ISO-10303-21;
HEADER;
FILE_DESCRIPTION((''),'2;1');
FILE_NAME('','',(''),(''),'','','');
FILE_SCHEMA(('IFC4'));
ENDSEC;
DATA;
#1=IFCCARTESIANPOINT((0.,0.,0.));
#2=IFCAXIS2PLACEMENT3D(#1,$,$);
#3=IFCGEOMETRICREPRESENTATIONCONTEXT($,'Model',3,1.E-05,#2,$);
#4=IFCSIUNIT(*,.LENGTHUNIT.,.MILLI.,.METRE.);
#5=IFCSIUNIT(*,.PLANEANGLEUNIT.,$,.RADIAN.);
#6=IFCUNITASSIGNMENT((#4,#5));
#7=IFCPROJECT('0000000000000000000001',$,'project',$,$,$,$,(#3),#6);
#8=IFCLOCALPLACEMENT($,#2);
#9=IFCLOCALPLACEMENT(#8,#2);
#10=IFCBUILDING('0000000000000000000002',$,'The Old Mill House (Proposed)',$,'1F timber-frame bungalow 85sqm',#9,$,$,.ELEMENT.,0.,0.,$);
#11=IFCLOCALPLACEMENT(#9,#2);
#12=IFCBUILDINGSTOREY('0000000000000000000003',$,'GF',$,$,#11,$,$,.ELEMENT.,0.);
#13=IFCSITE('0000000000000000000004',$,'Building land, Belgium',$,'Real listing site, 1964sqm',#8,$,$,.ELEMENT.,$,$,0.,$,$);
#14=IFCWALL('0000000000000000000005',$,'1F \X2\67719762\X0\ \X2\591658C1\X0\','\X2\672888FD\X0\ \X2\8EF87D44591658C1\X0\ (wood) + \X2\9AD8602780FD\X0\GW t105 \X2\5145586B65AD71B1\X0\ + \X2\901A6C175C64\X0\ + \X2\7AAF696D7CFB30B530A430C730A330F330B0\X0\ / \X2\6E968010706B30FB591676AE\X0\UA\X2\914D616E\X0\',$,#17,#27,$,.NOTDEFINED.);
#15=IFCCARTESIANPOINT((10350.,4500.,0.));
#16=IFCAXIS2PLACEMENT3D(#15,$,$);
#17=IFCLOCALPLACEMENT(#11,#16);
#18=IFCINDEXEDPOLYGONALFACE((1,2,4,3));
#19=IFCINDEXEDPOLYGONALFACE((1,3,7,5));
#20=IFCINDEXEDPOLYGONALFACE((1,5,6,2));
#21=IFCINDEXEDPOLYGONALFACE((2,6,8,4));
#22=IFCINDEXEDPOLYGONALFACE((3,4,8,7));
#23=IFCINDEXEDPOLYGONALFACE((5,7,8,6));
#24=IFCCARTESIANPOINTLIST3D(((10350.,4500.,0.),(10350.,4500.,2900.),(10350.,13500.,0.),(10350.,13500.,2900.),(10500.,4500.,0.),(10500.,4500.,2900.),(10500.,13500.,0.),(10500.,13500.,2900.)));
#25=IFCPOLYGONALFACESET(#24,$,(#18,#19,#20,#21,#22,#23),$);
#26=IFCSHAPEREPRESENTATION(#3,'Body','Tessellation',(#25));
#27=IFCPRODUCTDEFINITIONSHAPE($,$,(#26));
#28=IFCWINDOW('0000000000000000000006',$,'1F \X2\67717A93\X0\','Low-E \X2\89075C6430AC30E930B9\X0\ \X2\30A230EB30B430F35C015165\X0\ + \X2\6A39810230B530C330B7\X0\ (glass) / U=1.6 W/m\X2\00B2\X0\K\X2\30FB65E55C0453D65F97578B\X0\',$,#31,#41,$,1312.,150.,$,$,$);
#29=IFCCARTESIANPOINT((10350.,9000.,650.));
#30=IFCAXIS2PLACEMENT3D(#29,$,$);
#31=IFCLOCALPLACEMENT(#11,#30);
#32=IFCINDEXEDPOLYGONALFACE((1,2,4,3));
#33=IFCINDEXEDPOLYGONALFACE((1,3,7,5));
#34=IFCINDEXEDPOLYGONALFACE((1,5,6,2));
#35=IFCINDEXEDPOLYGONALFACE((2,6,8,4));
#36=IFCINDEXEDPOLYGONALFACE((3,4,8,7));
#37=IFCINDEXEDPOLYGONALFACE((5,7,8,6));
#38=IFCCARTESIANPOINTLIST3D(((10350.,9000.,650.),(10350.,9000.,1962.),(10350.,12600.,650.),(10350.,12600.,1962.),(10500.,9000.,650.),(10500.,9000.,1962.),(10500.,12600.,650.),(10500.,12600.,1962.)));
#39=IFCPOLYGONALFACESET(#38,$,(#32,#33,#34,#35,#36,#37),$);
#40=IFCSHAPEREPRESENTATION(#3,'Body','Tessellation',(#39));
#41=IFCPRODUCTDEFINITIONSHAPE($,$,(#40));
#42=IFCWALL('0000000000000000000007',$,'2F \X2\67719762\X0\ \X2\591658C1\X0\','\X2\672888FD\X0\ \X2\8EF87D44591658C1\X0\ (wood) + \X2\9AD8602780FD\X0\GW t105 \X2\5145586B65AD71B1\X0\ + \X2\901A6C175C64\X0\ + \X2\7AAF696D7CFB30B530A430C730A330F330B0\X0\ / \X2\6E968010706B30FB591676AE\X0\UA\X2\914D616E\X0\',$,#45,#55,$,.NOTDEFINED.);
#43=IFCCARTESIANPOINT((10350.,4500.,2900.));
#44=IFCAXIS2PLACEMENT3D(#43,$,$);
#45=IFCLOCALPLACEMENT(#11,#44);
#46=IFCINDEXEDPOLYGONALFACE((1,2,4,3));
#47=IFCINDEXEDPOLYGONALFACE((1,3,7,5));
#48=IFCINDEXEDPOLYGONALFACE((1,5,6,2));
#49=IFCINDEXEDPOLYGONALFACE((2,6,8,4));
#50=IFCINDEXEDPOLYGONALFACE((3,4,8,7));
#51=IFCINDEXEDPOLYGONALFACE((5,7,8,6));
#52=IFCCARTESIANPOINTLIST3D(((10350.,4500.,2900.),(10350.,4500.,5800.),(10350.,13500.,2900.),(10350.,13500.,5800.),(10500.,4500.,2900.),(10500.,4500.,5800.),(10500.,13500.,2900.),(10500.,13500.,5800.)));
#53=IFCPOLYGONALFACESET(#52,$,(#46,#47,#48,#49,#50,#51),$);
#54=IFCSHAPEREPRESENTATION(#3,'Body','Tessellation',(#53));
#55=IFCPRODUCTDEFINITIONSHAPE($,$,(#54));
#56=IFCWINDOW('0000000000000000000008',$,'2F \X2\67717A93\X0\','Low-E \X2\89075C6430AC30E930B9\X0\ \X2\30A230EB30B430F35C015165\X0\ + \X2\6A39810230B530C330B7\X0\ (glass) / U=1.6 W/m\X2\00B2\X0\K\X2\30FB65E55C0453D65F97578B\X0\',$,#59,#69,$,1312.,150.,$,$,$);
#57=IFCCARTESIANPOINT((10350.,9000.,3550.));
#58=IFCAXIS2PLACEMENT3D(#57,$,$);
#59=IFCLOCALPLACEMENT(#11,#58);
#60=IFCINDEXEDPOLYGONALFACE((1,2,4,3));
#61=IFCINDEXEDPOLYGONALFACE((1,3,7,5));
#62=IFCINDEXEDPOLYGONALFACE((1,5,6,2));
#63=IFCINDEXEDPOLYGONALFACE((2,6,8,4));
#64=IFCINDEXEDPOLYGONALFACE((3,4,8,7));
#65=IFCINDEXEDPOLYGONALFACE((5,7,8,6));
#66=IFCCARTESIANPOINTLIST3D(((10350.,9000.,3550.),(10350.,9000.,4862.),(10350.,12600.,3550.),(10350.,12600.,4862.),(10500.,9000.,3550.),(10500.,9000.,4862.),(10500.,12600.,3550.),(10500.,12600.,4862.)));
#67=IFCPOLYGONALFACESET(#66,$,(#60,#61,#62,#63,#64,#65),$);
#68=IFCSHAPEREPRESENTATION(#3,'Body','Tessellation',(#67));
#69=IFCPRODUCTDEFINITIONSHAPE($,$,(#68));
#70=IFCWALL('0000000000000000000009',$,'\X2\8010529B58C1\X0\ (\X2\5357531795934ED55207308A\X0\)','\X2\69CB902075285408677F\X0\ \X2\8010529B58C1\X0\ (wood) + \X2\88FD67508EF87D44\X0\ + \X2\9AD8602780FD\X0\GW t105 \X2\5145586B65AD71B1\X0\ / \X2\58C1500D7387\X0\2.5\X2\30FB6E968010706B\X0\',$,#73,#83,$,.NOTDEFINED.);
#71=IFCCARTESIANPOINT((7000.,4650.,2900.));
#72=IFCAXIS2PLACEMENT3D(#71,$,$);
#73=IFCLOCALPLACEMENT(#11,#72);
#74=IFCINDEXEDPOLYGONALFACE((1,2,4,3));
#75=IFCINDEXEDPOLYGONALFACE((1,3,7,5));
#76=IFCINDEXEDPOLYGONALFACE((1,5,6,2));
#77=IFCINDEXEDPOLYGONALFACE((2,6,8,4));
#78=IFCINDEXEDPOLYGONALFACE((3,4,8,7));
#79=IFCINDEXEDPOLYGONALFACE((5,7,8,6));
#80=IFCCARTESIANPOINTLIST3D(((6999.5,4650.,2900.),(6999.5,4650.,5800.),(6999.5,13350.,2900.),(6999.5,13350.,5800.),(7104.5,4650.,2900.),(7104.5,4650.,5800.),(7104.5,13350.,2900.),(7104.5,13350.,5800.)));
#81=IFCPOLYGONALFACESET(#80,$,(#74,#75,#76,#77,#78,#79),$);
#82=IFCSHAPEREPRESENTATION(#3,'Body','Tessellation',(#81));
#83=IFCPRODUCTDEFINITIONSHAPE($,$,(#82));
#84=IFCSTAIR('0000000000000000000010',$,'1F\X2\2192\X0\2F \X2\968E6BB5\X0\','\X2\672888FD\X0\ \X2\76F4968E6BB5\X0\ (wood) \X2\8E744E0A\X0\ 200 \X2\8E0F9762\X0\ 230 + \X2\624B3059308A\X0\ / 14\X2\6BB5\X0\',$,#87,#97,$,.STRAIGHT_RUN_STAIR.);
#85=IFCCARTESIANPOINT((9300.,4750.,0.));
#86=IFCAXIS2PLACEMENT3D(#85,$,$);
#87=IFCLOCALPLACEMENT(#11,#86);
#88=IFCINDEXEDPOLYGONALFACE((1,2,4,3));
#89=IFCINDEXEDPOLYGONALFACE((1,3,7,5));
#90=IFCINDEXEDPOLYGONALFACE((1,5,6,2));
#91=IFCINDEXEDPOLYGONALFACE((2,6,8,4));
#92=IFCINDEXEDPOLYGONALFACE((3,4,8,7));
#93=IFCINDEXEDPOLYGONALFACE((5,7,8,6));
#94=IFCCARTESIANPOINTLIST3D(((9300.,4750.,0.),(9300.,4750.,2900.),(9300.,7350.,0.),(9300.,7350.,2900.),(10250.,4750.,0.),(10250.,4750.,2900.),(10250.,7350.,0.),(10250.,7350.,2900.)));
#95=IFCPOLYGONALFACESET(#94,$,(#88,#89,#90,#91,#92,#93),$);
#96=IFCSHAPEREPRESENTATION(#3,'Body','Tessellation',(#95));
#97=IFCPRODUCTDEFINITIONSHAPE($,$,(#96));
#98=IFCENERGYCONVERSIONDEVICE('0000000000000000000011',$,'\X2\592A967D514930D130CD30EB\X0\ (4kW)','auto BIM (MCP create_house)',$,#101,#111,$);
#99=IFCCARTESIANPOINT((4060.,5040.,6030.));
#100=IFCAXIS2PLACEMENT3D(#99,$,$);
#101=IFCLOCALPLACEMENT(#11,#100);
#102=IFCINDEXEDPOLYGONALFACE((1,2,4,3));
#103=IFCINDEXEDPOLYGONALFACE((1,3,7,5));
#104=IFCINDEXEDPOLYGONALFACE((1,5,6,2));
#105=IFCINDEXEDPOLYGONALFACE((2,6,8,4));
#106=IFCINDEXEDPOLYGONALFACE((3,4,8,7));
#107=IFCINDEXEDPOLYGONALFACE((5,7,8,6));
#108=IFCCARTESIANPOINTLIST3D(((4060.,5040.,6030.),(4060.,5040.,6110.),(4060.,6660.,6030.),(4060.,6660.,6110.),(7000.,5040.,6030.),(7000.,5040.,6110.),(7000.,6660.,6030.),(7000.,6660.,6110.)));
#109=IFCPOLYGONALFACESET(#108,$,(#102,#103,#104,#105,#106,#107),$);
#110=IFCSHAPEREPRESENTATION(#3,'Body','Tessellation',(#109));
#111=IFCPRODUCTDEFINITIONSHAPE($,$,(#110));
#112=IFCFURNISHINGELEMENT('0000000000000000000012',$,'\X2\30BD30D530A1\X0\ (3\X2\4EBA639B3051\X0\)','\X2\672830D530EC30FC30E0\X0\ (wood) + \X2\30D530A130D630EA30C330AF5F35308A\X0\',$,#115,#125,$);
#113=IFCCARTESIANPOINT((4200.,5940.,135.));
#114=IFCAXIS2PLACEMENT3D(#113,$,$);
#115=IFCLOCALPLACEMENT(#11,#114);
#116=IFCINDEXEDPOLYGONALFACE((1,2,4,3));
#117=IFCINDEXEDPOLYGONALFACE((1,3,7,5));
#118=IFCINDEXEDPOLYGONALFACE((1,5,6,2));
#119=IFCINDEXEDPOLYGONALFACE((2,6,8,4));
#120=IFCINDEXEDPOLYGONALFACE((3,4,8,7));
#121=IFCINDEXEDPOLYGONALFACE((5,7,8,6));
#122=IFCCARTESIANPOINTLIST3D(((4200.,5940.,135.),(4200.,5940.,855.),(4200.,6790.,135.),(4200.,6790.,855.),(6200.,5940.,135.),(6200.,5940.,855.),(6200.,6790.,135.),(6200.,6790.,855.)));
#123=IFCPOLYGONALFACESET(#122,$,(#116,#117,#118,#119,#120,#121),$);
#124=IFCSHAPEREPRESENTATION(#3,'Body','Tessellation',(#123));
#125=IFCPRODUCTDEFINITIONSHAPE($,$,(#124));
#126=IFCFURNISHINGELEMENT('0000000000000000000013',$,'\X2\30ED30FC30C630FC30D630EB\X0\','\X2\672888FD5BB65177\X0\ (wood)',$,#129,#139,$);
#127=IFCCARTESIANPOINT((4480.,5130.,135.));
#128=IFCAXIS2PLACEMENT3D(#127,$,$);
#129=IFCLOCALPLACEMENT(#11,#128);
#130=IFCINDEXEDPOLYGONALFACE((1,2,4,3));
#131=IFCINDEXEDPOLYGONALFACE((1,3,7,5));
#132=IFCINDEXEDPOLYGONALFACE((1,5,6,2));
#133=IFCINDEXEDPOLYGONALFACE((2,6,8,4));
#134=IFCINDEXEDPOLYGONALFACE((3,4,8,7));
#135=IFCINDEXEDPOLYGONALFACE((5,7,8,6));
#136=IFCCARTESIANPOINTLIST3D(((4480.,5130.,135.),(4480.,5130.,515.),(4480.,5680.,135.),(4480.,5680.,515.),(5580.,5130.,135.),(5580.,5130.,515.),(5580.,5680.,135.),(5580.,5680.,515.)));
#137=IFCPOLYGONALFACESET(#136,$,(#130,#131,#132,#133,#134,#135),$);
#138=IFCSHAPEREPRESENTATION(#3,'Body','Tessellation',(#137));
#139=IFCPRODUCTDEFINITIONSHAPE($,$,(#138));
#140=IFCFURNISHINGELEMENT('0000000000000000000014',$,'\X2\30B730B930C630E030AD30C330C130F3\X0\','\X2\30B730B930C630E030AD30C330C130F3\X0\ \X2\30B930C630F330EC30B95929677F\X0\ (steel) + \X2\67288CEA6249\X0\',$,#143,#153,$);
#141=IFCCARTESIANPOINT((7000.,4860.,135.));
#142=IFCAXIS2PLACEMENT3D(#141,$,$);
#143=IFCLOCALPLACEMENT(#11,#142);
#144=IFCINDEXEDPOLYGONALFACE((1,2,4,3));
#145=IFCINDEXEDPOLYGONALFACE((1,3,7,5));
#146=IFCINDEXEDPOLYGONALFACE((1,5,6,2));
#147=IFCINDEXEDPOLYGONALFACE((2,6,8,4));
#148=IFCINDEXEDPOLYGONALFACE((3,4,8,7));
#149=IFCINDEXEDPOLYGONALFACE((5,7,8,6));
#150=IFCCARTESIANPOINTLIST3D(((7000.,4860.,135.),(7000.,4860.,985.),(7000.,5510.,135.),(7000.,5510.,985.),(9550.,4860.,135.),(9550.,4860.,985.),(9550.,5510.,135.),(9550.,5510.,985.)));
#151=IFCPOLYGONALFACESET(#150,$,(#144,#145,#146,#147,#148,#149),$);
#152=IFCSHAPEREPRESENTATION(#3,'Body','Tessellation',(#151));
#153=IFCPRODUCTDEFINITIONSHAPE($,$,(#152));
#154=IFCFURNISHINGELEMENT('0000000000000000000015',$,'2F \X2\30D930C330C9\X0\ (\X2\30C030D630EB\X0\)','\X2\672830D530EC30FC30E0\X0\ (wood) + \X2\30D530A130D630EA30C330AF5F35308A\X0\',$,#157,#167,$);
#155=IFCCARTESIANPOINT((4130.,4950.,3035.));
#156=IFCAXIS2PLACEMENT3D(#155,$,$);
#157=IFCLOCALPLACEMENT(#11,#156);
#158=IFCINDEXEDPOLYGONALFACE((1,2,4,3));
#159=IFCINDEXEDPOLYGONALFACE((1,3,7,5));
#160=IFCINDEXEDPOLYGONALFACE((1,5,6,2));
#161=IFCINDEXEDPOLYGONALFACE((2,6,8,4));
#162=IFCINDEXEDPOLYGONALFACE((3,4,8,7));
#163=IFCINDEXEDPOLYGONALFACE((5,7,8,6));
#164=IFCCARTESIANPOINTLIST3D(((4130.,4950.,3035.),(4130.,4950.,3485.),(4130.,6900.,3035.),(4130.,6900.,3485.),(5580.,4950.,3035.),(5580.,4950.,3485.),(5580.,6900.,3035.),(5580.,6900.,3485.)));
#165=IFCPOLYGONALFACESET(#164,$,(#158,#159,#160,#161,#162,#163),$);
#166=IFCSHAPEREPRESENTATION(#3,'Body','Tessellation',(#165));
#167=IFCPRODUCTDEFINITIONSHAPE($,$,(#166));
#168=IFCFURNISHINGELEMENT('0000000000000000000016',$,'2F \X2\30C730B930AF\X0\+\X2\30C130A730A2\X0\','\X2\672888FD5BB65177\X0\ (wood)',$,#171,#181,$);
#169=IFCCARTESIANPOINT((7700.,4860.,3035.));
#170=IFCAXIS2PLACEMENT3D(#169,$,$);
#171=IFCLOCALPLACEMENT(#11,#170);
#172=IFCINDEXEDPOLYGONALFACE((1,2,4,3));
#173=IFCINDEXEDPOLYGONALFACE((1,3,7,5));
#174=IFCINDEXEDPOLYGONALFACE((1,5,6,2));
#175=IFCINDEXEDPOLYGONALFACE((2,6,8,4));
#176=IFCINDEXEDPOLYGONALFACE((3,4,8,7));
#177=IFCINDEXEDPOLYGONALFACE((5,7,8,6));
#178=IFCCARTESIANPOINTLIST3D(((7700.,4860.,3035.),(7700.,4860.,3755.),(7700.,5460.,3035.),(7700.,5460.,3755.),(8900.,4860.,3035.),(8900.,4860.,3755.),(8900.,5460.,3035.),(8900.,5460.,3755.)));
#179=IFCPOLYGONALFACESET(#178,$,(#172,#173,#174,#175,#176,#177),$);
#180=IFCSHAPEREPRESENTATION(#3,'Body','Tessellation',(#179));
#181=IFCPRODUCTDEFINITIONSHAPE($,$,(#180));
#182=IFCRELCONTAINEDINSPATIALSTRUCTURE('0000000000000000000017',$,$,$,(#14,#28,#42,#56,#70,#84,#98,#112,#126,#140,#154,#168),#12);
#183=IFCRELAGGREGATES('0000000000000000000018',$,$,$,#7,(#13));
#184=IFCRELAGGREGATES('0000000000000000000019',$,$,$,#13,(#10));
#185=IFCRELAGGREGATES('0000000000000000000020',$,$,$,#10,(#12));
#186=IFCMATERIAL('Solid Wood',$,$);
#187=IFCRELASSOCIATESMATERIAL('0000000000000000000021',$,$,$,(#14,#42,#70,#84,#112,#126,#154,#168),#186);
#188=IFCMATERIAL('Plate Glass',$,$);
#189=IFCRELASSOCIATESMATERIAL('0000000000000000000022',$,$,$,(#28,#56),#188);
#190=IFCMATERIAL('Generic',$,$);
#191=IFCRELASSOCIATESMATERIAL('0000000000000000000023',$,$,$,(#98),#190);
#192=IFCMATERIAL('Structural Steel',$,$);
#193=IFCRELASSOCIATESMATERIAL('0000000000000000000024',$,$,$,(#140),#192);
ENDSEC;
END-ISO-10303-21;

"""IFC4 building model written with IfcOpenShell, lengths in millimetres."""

from ifc_helpers import new_model, si_unit, frame, frame_2d, origin, place, context, project, spatial, rectangle, extrude, material, element, fill, save


model = new_model("IFC4")

# Units and contexts
model_context = context("Model", 3, precision=1e-05, world=origin())
ifc_project = project(units=[si_unit("LENGTHUNIT", "METRE", prefix="MILLI"), si_unit("PLANEANGLEUNIT", "RADIAN")], contexts=[model_context])

# Site, building, storey
site_placement = place(None, origin())
site = spatial("IfcSite", under=ifc_project, at=site_placement, Name="Building land, Belgium", ObjectType="Real listing site, 1964sqm", CompositionType="ELEMENT", RefElevation=0.0)
building_placement = place(site_placement, origin())
building = spatial("IfcBuilding", under=site, at=building_placement, Name="The Old Mill House (Proposed)", ObjectType="1F timber-frame bungalow 85sqm", CompositionType="ELEMENT", ElevationOfRefHeight=0.0, ElevationOfTerrain=0.0)
storey_placement = place(building_placement, origin())
storey = spatial("IfcBuildingStorey", under=building, at=storey_placement, Name="GF", CompositionType="ELEMENT", Elevation=0.0)

# Wall, opening, window
ifc_material_1 = material(Name="Solid Wood")
wall_1_placement = place(storey_placement, frame((10350.0, 4500.0, 0.0)))
wall_1 = element("IfcWall", 1, at=wall_1_placement, inside=storey, material=ifc_material_1, Name="1F 東面 外壁", Description="木製 軸組外壁 (wood) + 高性能GW t105 充填断熱 + 通気層 + 窯業系サイディング / 準耐火・外皮UA配慮", PredefinedType="NOTDEFINED", context=model_context, shape_type="SweptSolid", body=[
    extrude(rectangle(XDim=150.0, YDim=9000.0, at=frame_2d((75.0, 4500.0))), frame((10350.0, 4500.0, 0.0)), (0.0, 0.0, 1.0), 2900.0),
])
opening_1_placement = place(storey_placement, frame((10350.0, 9000.0, 650.0)))
opening_1 = element("IfcOpeningElement", 2, at=opening_1_placement, cuts=wall_1, PredefinedType="NOTDEFINED", context=model_context, shape_type="SweptSolid", body=[
    extrude(rectangle(XDim=150.0, YDim=3600.0, at=frame_2d((75.0, 1800.0))), frame((10350.0, 9000.0, 650.0)), (0.0, 0.0, 1.0), 1312.0),
])
ifc_material_2 = material(Name="Plate Glass")
window_1_placement = place(storey_placement, frame((10350.0, 9000.0, 650.0)))
window_1 = element("IfcWindow", 3, at=window_1_placement, inside=storey, material=ifc_material_2, Name="1F 東窓", Description="Low-E 複層ガラス アルゴン封入 + 樹脂サッシ (glass) / U=1.6 W/m²K・日射取得型", OverallHeight=1312.0, OverallWidth=150.0, context=model_context, shape_type="SweptSolid", body=[
    extrude(rectangle(XDim=150.0, YDim=3600.0, at=frame_2d((75.0, 1800.0))), frame((10350.0, 9000.0, 650.0)), (0.0, 0.0, 1.0), 1312.0),
])
fill(opening_1, window_1)

# Wall, opening, window
wall_2_placement = place(storey_placement, frame((10350.0, 4500.0, 2900.0)))
wall_2 = element("IfcWall", 4, at=wall_2_placement, inside=storey, material=ifc_material_1, Name="2F 東面 外壁", Description="木製 軸組外壁 (wood) + 高性能GW t105 充填断熱 + 通気層 + 窯業系サイディング / 準耐火・外皮UA配慮", PredefinedType="NOTDEFINED", context=model_context, shape_type="SweptSolid", body=[
    extrude(rectangle(XDim=150.0, YDim=9000.0, at=frame_2d((75.0, 4500.0))), frame((10350.0, 4500.0, 2900.0)), (0.0, 0.0, 1.0), 2900.0),
])
opening_2_placement = place(storey_placement, frame((10350.0, 9000.0, 3550.0)))
opening_2 = element("IfcOpeningElement", 5, at=opening_2_placement, cuts=wall_2, PredefinedType="NOTDEFINED", context=model_context, shape_type="SweptSolid", body=[
    extrude(rectangle(XDim=150.0, YDim=3600.0, at=frame_2d((75.0, 1800.0))), frame((10350.0, 9000.0, 3550.0)), (0.0, 0.0, 1.0), 1312.0),
])
window_2_placement = place(storey_placement, frame((10350.0, 9000.0, 3550.0)))
window_2 = element("IfcWindow", 6, at=window_2_placement, inside=storey, material=ifc_material_2, Name="2F 東窓", Description="Low-E 複層ガラス アルゴン封入 + 樹脂サッシ (glass) / U=1.6 W/m²K・日射取得型", OverallHeight=1312.0, OverallWidth=150.0, context=model_context, shape_type="SweptSolid", body=[
    extrude(rectangle(XDim=150.0, YDim=3600.0, at=frame_2d((75.0, 1800.0))), frame((10350.0, 9000.0, 3550.0)), (0.0, 0.0, 1.0), 1312.0),
])
fill(opening_2, window_2)

# Wall
wall_3_placement = place(storey_placement, frame((7000.0, 4650.0, 2900.0)))
element("IfcWall", 7, at=wall_3_placement, inside=storey, material=ifc_material_1, Name="耐力壁 (南北間仕切り)", Description="構造用合板 耐力壁 (wood) + 製材軸組 + 高性能GW t105 充填断熱 / 壁倍率2.5・準耐火", PredefinedType="NOTDEFINED", context=model_context, shape_type="SweptSolid", body=[
    extrude(rectangle(XDim=105.0, YDim=8700.0, at=frame_2d((52.0, 4350.0))), frame((7000.0, 4650.0, 2900.0)), (0.0, 0.0, 1.0), 2900.0),
])

# Stair
stair_placement = place(storey_placement, frame((9300.0, 4750.0, 0.0)))
element("IfcStair", 8, at=stair_placement, inside=storey, material=ifc_material_1, Name="1F→2F 階段", Description="木製 直階段 (wood) 蹴上 200 踏面 230 + 手すり / 14段", PredefinedType="STRAIGHT_RUN_STAIR", context=model_context, shape_type="SweptSolid", body=[
    extrude(rectangle(XDim=950.0, YDim=2600.0, at=frame_2d((475.0, 1300.0))), frame((9300.0, 4750.0, 0.0)), (0.0, 0.0, 1.0), 2900.0),
])

# Energy conversion device
ifc_material_3 = material(Name="Generic")
energy_conversion_device_placement = place(storey_placement, frame((4060.0, 5040.0, 6030.0)))
element("IfcEnergyConversionDevice", 9, at=energy_conversion_device_placement, inside=storey, material=ifc_material_3, Name="太陽光パネル (4kW)", Description="auto BIM (MCP create_house)", context=model_context, shape_type="SweptSolid", body=[
    extrude(rectangle(XDim=2940.0, YDim=1620.0, at=frame_2d((1470.0, 810.0))), frame((4060.0, 5040.0, 6030.0)), (0.0, 0.0, 1.0), 80.0),
])

# Furnishing elements
furnishing_1_placement = place(storey_placement, frame((4200.0, 5940.0, 135.0)))
element("IfcFurnishingElement", 10, at=furnishing_1_placement, inside=storey, material=ifc_material_1, Name="ソファ (3人掛け)", Description="木フレーム (wood) + ファブリック張り", context=model_context, shape_type="SweptSolid", body=[
    extrude(rectangle(XDim=2000.0, YDim=850.0, at=frame_2d((1000.0, 425.0))), frame((4200.0, 5940.0, 135.0)), (0.0, 0.0, 1.0), 720.0),
])
furnishing_2_placement = place(storey_placement, frame((4480.0, 5130.0, 135.0)))
element("IfcFurnishingElement", 11, at=furnishing_2_placement, inside=storey, material=ifc_material_1, Name="ローテーブル", Description="木製家具 (wood)", context=model_context, shape_type="SweptSolid", body=[
    extrude(rectangle(XDim=1100.0, YDim=550.0, at=frame_2d((550.0, 275.0))), frame((4480.0, 5130.0, 135.0)), (0.0, 0.0, 1.0), 380.0),
])
ifc_material_4 = material(Name="Structural Steel")
furnishing_3_placement = place(storey_placement, frame((7000.0, 4860.0, 135.0)))
element("IfcFurnishingElement", 12, at=furnishing_3_placement, inside=storey, material=ifc_material_4, Name="システムキッチン", Description="システムキッチン ステンレス天板 (steel) + 木質扉", context=model_context, shape_type="SweptSolid", body=[
    extrude(rectangle(XDim=2550.0, YDim=650.0, at=frame_2d((1275.0, 325.0))), frame((7000.0, 4860.0, 135.0)), (0.0, 0.0, 1.0), 850.0),
])
furnishing_4_placement = place(storey_placement, frame((4130.0, 4950.0, 3035.0)))
element("IfcFurnishingElement", 13, at=furnishing_4_placement, inside=storey, material=ifc_material_1, Name="2F ベッド (ダブル)", Description="木フレーム (wood) + ファブリック張り", context=model_context, shape_type="SweptSolid", body=[
    extrude(rectangle(XDim=1450.0, YDim=1950.0, at=frame_2d((725.0, 975.0))), frame((4130.0, 4950.0, 3035.0)), (0.0, 0.0, 1.0), 450.0),
])
furnishing_5_placement = place(storey_placement, frame((7700.0, 4860.0, 3035.0)))
element("IfcFurnishingElement", 14, at=furnishing_5_placement, inside=storey, material=ifc_material_1, Name="2F デスク+チェア", Description="木製家具 (wood)", context=model_context, shape_type="SweptSolid", body=[
    extrude(rectangle(XDim=1200.0, YDim=600.0, at=frame_2d((600.0, 300.0))), frame((7700.0, 4860.0, 3035.0)), (0.0, 0.0, 1.0), 720.0),
])

save(model, "model.ifc")
